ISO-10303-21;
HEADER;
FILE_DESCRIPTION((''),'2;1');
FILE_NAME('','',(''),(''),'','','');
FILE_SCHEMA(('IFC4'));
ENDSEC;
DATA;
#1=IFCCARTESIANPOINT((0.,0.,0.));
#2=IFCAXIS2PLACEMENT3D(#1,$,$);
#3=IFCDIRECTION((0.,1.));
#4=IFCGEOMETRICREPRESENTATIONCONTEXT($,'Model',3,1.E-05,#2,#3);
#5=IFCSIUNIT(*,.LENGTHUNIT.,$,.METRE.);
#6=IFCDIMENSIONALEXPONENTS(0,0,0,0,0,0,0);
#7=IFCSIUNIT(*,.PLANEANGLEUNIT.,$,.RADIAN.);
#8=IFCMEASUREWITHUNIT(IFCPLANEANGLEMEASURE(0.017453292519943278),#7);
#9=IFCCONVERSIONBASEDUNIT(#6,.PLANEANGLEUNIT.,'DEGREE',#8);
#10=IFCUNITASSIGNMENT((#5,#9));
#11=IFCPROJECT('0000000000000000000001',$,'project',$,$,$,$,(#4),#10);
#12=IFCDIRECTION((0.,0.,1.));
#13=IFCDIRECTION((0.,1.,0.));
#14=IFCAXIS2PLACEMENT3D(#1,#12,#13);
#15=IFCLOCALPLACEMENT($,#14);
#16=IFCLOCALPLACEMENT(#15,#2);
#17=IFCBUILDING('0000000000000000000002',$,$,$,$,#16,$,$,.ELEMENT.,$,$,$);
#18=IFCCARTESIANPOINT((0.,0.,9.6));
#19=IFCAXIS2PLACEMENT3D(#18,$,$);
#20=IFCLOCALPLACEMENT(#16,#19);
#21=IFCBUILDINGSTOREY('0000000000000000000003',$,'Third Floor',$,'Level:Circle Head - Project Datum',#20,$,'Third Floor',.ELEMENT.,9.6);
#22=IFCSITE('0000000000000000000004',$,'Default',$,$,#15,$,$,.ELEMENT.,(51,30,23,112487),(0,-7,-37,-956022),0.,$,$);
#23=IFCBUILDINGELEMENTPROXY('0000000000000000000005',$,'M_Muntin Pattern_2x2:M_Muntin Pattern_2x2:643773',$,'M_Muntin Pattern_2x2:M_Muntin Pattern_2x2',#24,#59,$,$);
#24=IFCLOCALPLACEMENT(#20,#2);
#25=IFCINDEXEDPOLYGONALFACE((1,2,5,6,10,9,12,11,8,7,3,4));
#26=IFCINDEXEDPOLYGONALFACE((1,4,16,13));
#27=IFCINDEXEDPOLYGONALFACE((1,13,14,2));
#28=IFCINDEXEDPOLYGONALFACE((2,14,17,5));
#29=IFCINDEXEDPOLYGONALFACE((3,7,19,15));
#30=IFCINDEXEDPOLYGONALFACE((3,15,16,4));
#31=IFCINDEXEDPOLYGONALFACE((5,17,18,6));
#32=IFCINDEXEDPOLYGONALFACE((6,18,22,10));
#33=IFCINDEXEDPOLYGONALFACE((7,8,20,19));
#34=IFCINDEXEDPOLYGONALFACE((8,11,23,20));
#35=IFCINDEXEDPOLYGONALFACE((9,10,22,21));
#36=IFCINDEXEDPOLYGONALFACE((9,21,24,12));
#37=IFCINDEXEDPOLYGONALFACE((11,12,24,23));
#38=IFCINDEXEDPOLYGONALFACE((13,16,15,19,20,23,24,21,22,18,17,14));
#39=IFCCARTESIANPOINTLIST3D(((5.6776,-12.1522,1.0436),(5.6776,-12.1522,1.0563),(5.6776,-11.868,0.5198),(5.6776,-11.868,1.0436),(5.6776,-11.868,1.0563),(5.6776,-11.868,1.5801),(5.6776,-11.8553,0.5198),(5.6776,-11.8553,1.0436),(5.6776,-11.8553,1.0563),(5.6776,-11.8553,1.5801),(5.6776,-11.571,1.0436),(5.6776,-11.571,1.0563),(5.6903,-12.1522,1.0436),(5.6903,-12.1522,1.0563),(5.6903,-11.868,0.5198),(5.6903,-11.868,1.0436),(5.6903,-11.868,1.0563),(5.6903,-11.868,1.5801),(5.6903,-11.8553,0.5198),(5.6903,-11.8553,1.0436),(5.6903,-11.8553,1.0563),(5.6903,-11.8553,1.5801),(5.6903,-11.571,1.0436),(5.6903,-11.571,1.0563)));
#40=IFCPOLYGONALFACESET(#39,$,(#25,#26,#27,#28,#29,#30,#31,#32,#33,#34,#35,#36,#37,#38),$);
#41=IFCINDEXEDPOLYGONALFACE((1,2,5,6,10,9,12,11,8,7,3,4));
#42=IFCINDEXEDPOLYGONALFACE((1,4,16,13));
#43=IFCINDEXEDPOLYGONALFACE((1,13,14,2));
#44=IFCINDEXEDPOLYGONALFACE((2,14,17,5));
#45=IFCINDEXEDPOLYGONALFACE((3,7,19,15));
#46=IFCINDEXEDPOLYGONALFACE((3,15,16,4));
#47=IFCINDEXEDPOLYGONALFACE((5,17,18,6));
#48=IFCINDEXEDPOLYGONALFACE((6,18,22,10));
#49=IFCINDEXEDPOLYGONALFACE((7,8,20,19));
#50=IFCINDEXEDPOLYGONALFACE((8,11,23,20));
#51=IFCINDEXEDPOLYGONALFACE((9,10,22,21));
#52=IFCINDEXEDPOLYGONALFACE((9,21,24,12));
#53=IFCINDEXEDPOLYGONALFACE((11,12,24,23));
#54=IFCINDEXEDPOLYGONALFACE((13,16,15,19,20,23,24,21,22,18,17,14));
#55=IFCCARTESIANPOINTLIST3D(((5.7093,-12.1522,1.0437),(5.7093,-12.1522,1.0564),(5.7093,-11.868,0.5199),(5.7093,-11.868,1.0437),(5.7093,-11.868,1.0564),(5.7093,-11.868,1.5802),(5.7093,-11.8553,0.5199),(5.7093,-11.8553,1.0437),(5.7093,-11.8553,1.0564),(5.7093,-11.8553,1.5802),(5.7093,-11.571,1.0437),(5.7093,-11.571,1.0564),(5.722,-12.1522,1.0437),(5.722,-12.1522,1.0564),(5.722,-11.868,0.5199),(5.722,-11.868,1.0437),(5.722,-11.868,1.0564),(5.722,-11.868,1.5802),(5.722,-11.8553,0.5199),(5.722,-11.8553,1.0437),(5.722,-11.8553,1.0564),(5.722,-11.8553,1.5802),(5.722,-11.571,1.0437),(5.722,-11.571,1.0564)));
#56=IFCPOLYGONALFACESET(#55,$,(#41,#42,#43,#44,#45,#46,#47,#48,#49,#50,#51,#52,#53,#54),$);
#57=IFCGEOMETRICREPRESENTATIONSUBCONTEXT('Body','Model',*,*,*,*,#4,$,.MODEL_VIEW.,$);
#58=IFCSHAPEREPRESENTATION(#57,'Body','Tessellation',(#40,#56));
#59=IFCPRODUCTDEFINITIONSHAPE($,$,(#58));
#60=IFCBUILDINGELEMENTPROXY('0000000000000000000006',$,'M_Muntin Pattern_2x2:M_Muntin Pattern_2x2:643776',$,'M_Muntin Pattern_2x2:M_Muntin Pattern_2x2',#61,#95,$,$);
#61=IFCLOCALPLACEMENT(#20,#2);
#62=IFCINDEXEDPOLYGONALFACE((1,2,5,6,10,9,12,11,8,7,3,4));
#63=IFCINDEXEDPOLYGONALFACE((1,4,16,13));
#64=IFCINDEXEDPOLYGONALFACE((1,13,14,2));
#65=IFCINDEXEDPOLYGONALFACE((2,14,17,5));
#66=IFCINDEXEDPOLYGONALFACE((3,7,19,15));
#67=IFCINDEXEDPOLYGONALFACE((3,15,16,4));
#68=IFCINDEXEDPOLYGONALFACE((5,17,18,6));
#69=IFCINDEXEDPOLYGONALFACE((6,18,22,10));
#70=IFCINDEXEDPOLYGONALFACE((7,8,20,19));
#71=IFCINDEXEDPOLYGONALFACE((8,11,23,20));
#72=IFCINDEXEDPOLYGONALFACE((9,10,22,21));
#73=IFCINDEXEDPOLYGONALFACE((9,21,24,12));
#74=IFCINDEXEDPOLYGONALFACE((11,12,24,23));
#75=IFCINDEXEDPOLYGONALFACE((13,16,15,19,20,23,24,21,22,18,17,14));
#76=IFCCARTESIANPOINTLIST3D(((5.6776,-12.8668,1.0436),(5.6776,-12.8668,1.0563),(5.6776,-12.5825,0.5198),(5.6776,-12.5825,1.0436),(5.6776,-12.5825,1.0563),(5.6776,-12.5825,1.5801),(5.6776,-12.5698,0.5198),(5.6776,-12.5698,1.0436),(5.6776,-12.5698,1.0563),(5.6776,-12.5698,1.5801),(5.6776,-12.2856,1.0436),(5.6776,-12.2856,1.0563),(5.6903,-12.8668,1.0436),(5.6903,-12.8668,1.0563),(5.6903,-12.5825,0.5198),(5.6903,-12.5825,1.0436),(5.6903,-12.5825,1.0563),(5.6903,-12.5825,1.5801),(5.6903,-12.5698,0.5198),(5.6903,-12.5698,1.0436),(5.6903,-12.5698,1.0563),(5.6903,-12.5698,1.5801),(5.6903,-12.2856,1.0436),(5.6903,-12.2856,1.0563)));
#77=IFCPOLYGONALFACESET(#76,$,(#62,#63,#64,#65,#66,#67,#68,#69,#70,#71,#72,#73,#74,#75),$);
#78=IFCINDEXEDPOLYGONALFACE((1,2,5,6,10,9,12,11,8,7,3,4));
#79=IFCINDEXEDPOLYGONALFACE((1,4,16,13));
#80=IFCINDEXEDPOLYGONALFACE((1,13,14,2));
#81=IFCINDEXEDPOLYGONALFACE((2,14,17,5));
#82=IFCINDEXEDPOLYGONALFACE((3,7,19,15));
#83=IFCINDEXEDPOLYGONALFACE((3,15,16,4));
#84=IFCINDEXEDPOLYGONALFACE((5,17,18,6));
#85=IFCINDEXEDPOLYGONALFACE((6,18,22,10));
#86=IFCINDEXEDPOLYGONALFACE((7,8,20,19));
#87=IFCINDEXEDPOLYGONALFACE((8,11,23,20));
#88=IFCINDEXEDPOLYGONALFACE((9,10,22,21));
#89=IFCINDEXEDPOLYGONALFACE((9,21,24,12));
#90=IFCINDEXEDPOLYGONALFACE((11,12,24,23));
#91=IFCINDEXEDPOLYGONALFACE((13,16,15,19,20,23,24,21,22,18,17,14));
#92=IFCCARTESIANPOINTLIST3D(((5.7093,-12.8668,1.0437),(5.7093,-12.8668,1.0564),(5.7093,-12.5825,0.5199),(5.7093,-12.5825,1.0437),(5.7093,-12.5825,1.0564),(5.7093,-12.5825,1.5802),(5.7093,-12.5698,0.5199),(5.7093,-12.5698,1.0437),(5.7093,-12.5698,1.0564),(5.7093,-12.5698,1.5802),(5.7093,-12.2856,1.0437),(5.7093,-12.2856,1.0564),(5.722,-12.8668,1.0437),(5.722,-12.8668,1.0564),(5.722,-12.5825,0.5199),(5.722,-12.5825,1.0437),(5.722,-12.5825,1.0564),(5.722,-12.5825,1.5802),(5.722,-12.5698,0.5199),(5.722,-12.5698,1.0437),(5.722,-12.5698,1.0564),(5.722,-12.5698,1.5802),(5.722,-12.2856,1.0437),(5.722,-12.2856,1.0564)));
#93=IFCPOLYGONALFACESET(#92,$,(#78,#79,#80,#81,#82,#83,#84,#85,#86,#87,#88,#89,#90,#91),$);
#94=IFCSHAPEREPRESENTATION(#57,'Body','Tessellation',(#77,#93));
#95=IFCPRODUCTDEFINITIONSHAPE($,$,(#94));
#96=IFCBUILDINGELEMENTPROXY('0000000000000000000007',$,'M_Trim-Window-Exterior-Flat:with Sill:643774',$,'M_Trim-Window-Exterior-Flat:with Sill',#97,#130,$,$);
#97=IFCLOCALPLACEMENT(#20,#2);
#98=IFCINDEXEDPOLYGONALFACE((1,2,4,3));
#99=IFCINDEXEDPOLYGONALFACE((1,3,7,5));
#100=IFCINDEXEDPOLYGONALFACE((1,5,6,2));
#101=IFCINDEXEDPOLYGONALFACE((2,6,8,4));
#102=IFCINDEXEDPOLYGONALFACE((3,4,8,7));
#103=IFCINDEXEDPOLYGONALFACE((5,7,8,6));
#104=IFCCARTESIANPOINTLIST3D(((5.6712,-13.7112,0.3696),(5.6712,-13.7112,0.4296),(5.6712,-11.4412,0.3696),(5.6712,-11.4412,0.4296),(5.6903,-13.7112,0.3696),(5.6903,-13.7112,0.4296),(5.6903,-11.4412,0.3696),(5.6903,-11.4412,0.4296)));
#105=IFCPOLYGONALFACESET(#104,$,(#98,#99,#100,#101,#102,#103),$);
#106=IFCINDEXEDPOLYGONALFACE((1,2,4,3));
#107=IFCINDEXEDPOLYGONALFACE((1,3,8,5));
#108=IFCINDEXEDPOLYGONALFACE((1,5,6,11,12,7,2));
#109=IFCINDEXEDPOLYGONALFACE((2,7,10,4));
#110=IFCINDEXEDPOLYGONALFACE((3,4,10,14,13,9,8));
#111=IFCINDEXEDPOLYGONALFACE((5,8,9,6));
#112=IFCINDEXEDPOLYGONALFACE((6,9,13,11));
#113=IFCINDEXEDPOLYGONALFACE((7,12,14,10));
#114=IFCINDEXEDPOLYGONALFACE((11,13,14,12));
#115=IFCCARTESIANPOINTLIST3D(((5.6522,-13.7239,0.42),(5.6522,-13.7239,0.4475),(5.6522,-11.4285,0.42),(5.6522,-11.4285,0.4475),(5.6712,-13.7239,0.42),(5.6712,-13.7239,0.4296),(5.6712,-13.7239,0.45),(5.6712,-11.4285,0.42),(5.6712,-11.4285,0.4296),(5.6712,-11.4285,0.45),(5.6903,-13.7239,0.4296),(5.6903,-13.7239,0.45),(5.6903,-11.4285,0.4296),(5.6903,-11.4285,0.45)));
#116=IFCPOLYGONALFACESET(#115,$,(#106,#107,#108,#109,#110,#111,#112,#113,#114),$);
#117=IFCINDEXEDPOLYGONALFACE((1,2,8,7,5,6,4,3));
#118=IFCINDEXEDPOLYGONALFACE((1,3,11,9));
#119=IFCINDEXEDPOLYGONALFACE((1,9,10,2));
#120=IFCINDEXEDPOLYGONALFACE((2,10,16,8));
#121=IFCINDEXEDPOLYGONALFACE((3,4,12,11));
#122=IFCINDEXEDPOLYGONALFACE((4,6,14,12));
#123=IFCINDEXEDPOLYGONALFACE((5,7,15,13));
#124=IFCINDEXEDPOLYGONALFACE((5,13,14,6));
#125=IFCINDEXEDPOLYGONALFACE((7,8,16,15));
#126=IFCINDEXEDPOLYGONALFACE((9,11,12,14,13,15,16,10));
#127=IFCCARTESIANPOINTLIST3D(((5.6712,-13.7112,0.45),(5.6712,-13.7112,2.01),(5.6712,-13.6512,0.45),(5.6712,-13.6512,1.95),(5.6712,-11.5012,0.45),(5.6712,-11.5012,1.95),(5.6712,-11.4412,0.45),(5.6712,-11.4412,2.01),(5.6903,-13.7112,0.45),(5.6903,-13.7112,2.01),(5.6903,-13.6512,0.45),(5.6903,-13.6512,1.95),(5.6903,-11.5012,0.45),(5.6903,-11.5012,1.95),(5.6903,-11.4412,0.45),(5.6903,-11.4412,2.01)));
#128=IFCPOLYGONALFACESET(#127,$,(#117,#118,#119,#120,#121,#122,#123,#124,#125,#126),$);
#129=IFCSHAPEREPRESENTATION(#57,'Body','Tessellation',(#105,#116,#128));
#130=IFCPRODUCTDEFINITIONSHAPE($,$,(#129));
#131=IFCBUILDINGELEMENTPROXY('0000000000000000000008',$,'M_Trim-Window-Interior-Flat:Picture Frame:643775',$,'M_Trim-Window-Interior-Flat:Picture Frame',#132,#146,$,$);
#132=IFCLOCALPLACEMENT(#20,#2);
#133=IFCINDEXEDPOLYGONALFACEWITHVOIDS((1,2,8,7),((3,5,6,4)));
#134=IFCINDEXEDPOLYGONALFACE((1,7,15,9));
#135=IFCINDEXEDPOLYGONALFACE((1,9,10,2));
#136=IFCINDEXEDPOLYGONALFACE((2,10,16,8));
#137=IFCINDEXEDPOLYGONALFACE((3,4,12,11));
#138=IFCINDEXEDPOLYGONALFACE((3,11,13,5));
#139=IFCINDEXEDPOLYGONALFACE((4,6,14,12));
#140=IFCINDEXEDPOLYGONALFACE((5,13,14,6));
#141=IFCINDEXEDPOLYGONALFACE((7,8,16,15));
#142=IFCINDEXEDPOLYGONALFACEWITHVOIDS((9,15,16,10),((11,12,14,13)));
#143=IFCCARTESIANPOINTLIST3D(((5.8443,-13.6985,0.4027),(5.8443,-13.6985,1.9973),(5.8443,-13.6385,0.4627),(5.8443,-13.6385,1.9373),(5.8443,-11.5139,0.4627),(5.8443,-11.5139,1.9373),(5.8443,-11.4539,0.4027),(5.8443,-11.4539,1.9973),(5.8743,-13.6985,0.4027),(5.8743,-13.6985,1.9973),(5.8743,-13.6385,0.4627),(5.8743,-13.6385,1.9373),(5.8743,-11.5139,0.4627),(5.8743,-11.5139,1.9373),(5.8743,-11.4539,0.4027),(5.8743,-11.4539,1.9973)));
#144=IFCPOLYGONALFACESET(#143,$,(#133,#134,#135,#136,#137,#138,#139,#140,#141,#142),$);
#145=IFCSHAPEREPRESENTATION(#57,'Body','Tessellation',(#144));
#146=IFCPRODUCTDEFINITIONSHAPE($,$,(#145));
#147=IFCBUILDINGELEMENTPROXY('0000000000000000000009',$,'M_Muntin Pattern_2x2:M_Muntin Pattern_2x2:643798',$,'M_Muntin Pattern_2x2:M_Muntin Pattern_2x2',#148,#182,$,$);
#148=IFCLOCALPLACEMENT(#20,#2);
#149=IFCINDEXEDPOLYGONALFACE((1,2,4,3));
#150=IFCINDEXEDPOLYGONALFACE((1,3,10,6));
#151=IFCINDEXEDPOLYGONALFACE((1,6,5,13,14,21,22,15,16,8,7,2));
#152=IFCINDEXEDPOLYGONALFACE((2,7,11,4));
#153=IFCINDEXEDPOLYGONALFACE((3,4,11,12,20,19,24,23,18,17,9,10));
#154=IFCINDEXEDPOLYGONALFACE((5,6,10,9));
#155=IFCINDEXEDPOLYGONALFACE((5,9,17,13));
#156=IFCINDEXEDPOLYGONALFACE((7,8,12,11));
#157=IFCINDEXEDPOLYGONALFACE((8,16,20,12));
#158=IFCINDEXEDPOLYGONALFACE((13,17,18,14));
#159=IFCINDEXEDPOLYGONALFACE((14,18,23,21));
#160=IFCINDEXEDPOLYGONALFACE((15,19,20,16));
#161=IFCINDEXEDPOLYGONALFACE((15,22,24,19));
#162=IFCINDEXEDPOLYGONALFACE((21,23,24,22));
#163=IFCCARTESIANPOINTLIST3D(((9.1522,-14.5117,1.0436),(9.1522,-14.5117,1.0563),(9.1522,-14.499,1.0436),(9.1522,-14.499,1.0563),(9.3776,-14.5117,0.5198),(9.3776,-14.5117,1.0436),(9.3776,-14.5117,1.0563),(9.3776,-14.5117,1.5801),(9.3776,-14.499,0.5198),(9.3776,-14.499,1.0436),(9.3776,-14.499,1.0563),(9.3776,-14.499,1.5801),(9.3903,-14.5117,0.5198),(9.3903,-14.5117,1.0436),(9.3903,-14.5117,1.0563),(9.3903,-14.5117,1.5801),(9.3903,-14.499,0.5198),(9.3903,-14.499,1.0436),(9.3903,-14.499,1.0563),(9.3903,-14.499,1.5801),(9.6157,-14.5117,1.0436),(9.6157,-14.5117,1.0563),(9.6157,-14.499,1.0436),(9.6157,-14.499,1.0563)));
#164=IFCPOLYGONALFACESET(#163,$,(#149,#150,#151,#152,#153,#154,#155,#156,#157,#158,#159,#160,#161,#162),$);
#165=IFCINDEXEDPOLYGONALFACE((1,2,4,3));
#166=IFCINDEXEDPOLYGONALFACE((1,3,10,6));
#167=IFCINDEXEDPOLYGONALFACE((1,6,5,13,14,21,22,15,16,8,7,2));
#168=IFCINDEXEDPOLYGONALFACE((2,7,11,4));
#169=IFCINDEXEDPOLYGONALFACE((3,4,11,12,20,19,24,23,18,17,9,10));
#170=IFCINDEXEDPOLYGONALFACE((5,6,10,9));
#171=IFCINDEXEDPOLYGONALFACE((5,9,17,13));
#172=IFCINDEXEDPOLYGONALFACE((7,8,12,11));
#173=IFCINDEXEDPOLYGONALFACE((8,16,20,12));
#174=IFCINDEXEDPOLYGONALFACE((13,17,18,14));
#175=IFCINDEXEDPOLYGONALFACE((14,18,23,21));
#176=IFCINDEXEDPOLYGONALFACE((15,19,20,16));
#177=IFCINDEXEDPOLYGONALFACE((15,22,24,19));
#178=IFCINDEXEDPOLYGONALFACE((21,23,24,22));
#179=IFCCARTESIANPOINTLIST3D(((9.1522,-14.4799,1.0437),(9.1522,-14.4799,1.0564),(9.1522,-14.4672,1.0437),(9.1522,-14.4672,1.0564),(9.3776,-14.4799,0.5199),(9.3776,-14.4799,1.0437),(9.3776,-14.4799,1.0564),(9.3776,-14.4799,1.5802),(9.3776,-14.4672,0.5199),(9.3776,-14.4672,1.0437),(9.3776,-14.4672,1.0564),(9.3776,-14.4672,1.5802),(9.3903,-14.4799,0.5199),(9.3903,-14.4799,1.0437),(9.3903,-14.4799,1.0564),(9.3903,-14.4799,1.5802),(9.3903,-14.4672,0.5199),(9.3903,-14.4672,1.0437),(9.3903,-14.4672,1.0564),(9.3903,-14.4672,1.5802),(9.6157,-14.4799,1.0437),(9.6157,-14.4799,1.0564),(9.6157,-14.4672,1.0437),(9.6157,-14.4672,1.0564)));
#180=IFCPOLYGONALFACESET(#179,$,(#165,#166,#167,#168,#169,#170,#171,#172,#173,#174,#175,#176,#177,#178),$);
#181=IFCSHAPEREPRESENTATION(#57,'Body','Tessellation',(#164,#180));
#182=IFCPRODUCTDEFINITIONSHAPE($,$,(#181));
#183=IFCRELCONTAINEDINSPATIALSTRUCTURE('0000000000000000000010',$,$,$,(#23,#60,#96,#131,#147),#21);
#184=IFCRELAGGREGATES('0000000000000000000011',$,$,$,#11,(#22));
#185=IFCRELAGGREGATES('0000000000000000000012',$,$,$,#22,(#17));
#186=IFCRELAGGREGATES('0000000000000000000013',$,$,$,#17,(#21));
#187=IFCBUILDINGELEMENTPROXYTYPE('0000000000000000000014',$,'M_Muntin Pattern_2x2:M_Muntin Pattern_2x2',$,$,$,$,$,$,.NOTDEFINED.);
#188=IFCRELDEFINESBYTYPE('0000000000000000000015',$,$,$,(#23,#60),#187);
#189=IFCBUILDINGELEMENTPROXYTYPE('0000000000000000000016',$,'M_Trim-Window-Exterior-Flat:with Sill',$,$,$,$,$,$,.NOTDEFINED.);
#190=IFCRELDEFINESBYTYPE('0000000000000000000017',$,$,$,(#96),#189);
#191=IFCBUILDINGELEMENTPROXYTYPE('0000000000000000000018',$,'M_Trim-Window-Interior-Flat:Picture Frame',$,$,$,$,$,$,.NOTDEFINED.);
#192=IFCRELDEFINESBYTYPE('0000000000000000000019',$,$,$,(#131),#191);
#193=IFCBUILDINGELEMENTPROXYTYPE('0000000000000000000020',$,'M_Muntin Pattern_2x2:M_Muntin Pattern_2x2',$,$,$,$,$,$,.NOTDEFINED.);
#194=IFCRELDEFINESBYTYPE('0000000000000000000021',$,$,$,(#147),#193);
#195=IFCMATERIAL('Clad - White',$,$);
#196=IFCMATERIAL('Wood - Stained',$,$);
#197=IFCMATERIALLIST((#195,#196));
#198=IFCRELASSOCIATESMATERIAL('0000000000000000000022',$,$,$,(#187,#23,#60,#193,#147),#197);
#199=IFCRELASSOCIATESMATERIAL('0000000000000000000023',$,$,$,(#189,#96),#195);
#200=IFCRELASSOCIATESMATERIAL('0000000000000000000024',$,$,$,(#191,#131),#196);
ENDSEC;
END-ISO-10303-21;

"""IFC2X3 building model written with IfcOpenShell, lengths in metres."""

from ifc_helpers import new_model, entity, si_unit, converted_unit, direction, frame, frame_2d, origin, place, context, subcontext, project, spatial, polyline, rectangle, outline, extrude, source, transform, mapped, material, material_list, type_object, type_shapes, element, save


model = new_model("IFC2X3")

# Units and contexts
model_context = context("Model", 3, precision=1e-05, world=origin(), true_north=direction((0.0, 1.0)))
body_context = subcontext(model_context, "Body", "Model", "MODEL_VIEW")
ifc_project = project(units=[si_unit("LENGTHUNIT", "METRE"), converted_unit("PLANEANGLEUNIT", "DEGREE", entity("IfcPlaneAngleMeasure", 0.017453292519943278), si_unit("PLANEANGLEUNIT", "RADIAN"), dimensions=[0, 0, 0, 0, 0, 0, 0])], contexts=[model_context])

# Site, building, storey
site_placement = place(None, frame((0.0, 0.0, 0.0), z_axis=(0.0, 0.0, 1.0), x_axis=(0.0, 1.0, 0.0)))
site = spatial("IfcSite", under=ifc_project, at=site_placement, Name="Default", CompositionType="ELEMENT", RefLatitude=(51, 30, 23, 112487), RefLongitude=(0, -7, -37, -956022), RefElevation=0.0)
building_placement = place(site_placement, origin())
building = spatial("IfcBuilding", under=site, at=building_placement, CompositionType="ELEMENT")
storey_placement = place(building_placement, frame((0.0, 0.0, 9.6)))
storey = spatial("IfcBuildingStorey", under=building, at=storey_placement, Name="Third Floor", ObjectType="Level:Circle Head - Project Datum", LongName="Third Floor", CompositionType="ELEMENT", Elevation=9.6)

# Building element proxies
ifc_material_1 = material(Name="Clad - White")
ifc_material_2 = material(Name="Wood - Stained")
ifc_material_list = material_list([ifc_material_1, ifc_material_2])
building_element_proxy_type_1 = type_object("IfcBuildingElementProxyType", Name="M_Muntin Pattern_2x2:M_Muntin Pattern_2x2", PredefinedType="NOTDEFINED", material=ifc_material_list)
shared_shape_1 = source(origin(), body_context, "Body", "SweptSolid", [
    extrude(outline(polyline([(0.0064, -0.0064), (0.5301, -0.0064), (0.5301, 0.0063), (0.0064, 0.0063), (0.0064, 0.2906), (-0.0063, 0.2906), (-0.0063, 0.0063), (-0.5302, 0.0063), (-0.5302, -0.0064), (-0.0063, -0.0064), (-0.0063, -0.2906), (0.0064, -0.2906), (0.0064, -0.0064)])), frame((0.0, -0.0222, 0.5301), z_axis=(0.0, 1.0, 0.0), x_axis=(0.0, 0.0, 1.0)), (0.0, 0.0, 1.0), 0.0127),
    extrude(outline(polyline([(0.0064, -0.0064), (0.5302, -0.0064), (0.5302, 0.0063), (0.0064, 0.0063), (0.0064, 0.2906), (-0.0063, 0.2906), (-0.0063, 0.0063), (-0.5302, 0.0063), (-0.5302, -0.0064), (-0.0063, -0.0064), (-0.0063, -0.2906), (0.0064, -0.2906), (0.0064, -0.0064)])), frame((0.0, 0.0095, 0.5302), z_axis=(0.0, 1.0, 0.0), x_axis=(0.0, 0.0, 1.0)), (0.0, 0.0, 1.0), 0.0127),
])
type_shapes(building_element_proxy_type_1, [shared_shape_1])
for number, where, z_axis, x_axis, name in (
    (1, (5.6998, -11.8616, 0.5199), (0.0, 0.0, 1.0), (0.0, -1.0, 0.0), "M_Muntin Pattern_2x2:M_Muntin Pattern_2x2:643773"),
    (2, (5.6998, -12.5762, 0.5199), (0.0, 0.0, 1.0), (0.0, -1.0, 0.0), "M_Muntin Pattern_2x2:M_Muntin Pattern_2x2:643776"),
):
    element("IfcBuildingElementProxy", number, at=place(storey_placement, frame(where, z_axis=z_axis, x_axis=x_axis)), inside=storey, type_object=building_element_proxy_type_1, material=ifc_material_list, Name=name, ObjectType="M_Muntin Pattern_2x2:M_Muntin Pattern_2x2", context=body_context, shape_type="MappedRepresentation", body=[
        mapped(shared_shape_1, transform((0.0, 0.0, 0.0), scale=1.0)),
    ])
building_element_proxy_type_2 = type_object("IfcBuildingElementProxyType", Name="M_Trim-Window-Exterior-Flat:with Sill", PredefinedType="NOTDEFINED", material=ifc_material_1)
shared_shape_2 = source(origin(), body_context, "Body", "SweptSolid", [
    extrude(rectangle(XDim=2.27, YDim=0.06, at=frame_2d((0.0, 0.0), x_axis=(1.0, 0.0))), frame((0.0, -1.5504, 0.0), z_axis=(0.0, 0.0, 1.0), x_axis=(-1.0, 0.0, 0.0)), (0.0, 0.0, 1.0), 0.019),
    extrude(outline(polyline([(-0.019, -0.0152), (0.0, -0.0152), (0.0, -0.0057), (0.019, -0.0057), (0.019, 0.0148), (0.0, 0.0148), (-0.019, 0.0123), (-0.019, -0.0152)])), frame((-1.1477, -1.5148, 0.019), z_axis=(1.0, 0.0, 0.0), x_axis=(0.0, 0.0, -1.0)), (0.0, 0.0, 1.0), 2.2954),
    extrude(outline(polyline([(-0.795, -1.135), (0.765, -1.135), (0.765, -1.075), (-0.735, -1.075), (-0.735, 1.075), (0.765, 1.075), (0.765, 1.135), (-0.795, 1.135), (-0.795, -1.135)])), frame((0.0, -0.735, 0.0), z_axis=(0.0, 0.0, 1.0), x_axis=(0.0, -1.0, 0.0)), (0.0, 0.0, 1.0), 0.019),
])
type_shapes(building_element_proxy_type_2, [shared_shape_2])
proxy_1_placement = place(storey_placement, frame((5.6903, -12.5762, 1.95), z_axis=(-1.0, 0.0, 0.0), x_axis=(0.0, -1.0, 0.0)))
element("IfcBuildingElementProxy", 3, at=proxy_1_placement, inside=storey, type_object=building_element_proxy_type_2, material=ifc_material_1, Name="M_Trim-Window-Exterior-Flat:with Sill:643774", ObjectType="M_Trim-Window-Exterior-Flat:with Sill", context=body_context, shape_type="MappedRepresentation", body=[
    mapped(shared_shape_2, transform((0.0, 0.0, 0.0), scale=1.0)),
])
building_element_proxy_type_3 = type_object("IfcBuildingElementProxyType", Name="M_Trim-Window-Interior-Flat:Picture Frame", PredefinedType="NOTDEFINED", material=ifc_material_2)
shared_shape_3 = source(origin(), body_context, "Body", "SweptSolid", [
    extrude(outline(polyline([(-1.1223, -0.7973), (1.1223, -0.7973), (1.1223, 0.7973), (-1.1223, 0.7973), (-1.1223, -0.7973)]), holes=[polyline([(-1.0623, -0.7373), (-1.0623, 0.7373), (1.0623, 0.7373), (1.0623, -0.7373), (-1.0623, -0.7373)])]), frame((0.0, -0.75, 0.0), z_axis=(0.0, 0.0, 1.0), x_axis=(-1.0, 0.0, 0.0)), (0.0, 0.0, 1.0), 0.03),
])
type_shapes(building_element_proxy_type_3, [shared_shape_3])
proxy_2_placement = place(storey_placement, frame((5.8443, -12.5762, 1.95), z_axis=(1.0, 0.0, 0.0), x_axis=(0.0, 1.0, 0.0)))
element("IfcBuildingElementProxy", 4, at=proxy_2_placement, inside=storey, type_object=building_element_proxy_type_3, material=ifc_material_2, Name="M_Trim-Window-Interior-Flat:Picture Frame:643775", ObjectType="M_Trim-Window-Interior-Flat:Picture Frame", context=body_context, shape_type="MappedRepresentation", body=[
    mapped(shared_shape_3, transform((0.0, 0.0, 0.0), scale=1.0)),
])
building_element_proxy_type_4 = type_object("IfcBuildingElementProxyType", Name="M_Muntin Pattern_2x2:M_Muntin Pattern_2x2", PredefinedType="NOTDEFINED", material=ifc_material_list)
shared_shape_4 = source(origin(), body_context, "Body", "SweptSolid", [
    extrude(outline(polyline([(0.0064, -0.0064), (0.5301, -0.0064), (0.5301, 0.0063), (0.0064, 0.0063), (0.0064, 0.2317), (-0.0063, 0.2317), (-0.0063, 0.0063), (-0.5302, 0.0063), (-0.5302, -0.0064), (-0.0063, -0.0064), (-0.0063, -0.2317), (0.0064, -0.2317), (0.0064, -0.0064)])), frame((0.0, 0.0095, 0.5301), z_axis=(0.0, 1.0, 0.0), x_axis=(0.0, 0.0, 1.0)), (0.0, 0.0, 1.0), 0.0127),
    extrude(outline(polyline([(0.0064, -0.0064), (0.5302, -0.0064), (0.5302, 0.0063), (0.0064, 0.0063), (0.0064, 0.2317), (-0.0063, 0.2317), (-0.0063, 0.0063), (-0.5302, 0.0063), (-0.5302, -0.0064), (-0.0063, -0.0064), (-0.0063, -0.2317), (0.0064, -0.2317), (0.0064, -0.0064)])), frame((0.0, -0.0222, 0.5302), z_axis=(0.0, 1.0, 0.0), x_axis=(0.0, 0.0, 1.0)), (0.0, 0.0, 1.0), 0.0127),
])
type_shapes(building_element_proxy_type_4, [shared_shape_4])
proxy_3_placement = place(storey_placement, frame((9.3839, -14.4895, 0.5199), z_axis=(0.0, 0.0, 1.0), x_axis=(-1.0, 0.0, 0.0)))
element("IfcBuildingElementProxy", 5, at=proxy_3_placement, inside=storey, type_object=building_element_proxy_type_4, material=ifc_material_list, Name="M_Muntin Pattern_2x2:M_Muntin Pattern_2x2:643798", ObjectType="M_Muntin Pattern_2x2:M_Muntin Pattern_2x2", context=body_context, shape_type="MappedRepresentation", body=[
    mapped(shared_shape_4, transform((0.0, 0.0, 0.0), scale=1.0)),
])

save(model, "model.ifc")
